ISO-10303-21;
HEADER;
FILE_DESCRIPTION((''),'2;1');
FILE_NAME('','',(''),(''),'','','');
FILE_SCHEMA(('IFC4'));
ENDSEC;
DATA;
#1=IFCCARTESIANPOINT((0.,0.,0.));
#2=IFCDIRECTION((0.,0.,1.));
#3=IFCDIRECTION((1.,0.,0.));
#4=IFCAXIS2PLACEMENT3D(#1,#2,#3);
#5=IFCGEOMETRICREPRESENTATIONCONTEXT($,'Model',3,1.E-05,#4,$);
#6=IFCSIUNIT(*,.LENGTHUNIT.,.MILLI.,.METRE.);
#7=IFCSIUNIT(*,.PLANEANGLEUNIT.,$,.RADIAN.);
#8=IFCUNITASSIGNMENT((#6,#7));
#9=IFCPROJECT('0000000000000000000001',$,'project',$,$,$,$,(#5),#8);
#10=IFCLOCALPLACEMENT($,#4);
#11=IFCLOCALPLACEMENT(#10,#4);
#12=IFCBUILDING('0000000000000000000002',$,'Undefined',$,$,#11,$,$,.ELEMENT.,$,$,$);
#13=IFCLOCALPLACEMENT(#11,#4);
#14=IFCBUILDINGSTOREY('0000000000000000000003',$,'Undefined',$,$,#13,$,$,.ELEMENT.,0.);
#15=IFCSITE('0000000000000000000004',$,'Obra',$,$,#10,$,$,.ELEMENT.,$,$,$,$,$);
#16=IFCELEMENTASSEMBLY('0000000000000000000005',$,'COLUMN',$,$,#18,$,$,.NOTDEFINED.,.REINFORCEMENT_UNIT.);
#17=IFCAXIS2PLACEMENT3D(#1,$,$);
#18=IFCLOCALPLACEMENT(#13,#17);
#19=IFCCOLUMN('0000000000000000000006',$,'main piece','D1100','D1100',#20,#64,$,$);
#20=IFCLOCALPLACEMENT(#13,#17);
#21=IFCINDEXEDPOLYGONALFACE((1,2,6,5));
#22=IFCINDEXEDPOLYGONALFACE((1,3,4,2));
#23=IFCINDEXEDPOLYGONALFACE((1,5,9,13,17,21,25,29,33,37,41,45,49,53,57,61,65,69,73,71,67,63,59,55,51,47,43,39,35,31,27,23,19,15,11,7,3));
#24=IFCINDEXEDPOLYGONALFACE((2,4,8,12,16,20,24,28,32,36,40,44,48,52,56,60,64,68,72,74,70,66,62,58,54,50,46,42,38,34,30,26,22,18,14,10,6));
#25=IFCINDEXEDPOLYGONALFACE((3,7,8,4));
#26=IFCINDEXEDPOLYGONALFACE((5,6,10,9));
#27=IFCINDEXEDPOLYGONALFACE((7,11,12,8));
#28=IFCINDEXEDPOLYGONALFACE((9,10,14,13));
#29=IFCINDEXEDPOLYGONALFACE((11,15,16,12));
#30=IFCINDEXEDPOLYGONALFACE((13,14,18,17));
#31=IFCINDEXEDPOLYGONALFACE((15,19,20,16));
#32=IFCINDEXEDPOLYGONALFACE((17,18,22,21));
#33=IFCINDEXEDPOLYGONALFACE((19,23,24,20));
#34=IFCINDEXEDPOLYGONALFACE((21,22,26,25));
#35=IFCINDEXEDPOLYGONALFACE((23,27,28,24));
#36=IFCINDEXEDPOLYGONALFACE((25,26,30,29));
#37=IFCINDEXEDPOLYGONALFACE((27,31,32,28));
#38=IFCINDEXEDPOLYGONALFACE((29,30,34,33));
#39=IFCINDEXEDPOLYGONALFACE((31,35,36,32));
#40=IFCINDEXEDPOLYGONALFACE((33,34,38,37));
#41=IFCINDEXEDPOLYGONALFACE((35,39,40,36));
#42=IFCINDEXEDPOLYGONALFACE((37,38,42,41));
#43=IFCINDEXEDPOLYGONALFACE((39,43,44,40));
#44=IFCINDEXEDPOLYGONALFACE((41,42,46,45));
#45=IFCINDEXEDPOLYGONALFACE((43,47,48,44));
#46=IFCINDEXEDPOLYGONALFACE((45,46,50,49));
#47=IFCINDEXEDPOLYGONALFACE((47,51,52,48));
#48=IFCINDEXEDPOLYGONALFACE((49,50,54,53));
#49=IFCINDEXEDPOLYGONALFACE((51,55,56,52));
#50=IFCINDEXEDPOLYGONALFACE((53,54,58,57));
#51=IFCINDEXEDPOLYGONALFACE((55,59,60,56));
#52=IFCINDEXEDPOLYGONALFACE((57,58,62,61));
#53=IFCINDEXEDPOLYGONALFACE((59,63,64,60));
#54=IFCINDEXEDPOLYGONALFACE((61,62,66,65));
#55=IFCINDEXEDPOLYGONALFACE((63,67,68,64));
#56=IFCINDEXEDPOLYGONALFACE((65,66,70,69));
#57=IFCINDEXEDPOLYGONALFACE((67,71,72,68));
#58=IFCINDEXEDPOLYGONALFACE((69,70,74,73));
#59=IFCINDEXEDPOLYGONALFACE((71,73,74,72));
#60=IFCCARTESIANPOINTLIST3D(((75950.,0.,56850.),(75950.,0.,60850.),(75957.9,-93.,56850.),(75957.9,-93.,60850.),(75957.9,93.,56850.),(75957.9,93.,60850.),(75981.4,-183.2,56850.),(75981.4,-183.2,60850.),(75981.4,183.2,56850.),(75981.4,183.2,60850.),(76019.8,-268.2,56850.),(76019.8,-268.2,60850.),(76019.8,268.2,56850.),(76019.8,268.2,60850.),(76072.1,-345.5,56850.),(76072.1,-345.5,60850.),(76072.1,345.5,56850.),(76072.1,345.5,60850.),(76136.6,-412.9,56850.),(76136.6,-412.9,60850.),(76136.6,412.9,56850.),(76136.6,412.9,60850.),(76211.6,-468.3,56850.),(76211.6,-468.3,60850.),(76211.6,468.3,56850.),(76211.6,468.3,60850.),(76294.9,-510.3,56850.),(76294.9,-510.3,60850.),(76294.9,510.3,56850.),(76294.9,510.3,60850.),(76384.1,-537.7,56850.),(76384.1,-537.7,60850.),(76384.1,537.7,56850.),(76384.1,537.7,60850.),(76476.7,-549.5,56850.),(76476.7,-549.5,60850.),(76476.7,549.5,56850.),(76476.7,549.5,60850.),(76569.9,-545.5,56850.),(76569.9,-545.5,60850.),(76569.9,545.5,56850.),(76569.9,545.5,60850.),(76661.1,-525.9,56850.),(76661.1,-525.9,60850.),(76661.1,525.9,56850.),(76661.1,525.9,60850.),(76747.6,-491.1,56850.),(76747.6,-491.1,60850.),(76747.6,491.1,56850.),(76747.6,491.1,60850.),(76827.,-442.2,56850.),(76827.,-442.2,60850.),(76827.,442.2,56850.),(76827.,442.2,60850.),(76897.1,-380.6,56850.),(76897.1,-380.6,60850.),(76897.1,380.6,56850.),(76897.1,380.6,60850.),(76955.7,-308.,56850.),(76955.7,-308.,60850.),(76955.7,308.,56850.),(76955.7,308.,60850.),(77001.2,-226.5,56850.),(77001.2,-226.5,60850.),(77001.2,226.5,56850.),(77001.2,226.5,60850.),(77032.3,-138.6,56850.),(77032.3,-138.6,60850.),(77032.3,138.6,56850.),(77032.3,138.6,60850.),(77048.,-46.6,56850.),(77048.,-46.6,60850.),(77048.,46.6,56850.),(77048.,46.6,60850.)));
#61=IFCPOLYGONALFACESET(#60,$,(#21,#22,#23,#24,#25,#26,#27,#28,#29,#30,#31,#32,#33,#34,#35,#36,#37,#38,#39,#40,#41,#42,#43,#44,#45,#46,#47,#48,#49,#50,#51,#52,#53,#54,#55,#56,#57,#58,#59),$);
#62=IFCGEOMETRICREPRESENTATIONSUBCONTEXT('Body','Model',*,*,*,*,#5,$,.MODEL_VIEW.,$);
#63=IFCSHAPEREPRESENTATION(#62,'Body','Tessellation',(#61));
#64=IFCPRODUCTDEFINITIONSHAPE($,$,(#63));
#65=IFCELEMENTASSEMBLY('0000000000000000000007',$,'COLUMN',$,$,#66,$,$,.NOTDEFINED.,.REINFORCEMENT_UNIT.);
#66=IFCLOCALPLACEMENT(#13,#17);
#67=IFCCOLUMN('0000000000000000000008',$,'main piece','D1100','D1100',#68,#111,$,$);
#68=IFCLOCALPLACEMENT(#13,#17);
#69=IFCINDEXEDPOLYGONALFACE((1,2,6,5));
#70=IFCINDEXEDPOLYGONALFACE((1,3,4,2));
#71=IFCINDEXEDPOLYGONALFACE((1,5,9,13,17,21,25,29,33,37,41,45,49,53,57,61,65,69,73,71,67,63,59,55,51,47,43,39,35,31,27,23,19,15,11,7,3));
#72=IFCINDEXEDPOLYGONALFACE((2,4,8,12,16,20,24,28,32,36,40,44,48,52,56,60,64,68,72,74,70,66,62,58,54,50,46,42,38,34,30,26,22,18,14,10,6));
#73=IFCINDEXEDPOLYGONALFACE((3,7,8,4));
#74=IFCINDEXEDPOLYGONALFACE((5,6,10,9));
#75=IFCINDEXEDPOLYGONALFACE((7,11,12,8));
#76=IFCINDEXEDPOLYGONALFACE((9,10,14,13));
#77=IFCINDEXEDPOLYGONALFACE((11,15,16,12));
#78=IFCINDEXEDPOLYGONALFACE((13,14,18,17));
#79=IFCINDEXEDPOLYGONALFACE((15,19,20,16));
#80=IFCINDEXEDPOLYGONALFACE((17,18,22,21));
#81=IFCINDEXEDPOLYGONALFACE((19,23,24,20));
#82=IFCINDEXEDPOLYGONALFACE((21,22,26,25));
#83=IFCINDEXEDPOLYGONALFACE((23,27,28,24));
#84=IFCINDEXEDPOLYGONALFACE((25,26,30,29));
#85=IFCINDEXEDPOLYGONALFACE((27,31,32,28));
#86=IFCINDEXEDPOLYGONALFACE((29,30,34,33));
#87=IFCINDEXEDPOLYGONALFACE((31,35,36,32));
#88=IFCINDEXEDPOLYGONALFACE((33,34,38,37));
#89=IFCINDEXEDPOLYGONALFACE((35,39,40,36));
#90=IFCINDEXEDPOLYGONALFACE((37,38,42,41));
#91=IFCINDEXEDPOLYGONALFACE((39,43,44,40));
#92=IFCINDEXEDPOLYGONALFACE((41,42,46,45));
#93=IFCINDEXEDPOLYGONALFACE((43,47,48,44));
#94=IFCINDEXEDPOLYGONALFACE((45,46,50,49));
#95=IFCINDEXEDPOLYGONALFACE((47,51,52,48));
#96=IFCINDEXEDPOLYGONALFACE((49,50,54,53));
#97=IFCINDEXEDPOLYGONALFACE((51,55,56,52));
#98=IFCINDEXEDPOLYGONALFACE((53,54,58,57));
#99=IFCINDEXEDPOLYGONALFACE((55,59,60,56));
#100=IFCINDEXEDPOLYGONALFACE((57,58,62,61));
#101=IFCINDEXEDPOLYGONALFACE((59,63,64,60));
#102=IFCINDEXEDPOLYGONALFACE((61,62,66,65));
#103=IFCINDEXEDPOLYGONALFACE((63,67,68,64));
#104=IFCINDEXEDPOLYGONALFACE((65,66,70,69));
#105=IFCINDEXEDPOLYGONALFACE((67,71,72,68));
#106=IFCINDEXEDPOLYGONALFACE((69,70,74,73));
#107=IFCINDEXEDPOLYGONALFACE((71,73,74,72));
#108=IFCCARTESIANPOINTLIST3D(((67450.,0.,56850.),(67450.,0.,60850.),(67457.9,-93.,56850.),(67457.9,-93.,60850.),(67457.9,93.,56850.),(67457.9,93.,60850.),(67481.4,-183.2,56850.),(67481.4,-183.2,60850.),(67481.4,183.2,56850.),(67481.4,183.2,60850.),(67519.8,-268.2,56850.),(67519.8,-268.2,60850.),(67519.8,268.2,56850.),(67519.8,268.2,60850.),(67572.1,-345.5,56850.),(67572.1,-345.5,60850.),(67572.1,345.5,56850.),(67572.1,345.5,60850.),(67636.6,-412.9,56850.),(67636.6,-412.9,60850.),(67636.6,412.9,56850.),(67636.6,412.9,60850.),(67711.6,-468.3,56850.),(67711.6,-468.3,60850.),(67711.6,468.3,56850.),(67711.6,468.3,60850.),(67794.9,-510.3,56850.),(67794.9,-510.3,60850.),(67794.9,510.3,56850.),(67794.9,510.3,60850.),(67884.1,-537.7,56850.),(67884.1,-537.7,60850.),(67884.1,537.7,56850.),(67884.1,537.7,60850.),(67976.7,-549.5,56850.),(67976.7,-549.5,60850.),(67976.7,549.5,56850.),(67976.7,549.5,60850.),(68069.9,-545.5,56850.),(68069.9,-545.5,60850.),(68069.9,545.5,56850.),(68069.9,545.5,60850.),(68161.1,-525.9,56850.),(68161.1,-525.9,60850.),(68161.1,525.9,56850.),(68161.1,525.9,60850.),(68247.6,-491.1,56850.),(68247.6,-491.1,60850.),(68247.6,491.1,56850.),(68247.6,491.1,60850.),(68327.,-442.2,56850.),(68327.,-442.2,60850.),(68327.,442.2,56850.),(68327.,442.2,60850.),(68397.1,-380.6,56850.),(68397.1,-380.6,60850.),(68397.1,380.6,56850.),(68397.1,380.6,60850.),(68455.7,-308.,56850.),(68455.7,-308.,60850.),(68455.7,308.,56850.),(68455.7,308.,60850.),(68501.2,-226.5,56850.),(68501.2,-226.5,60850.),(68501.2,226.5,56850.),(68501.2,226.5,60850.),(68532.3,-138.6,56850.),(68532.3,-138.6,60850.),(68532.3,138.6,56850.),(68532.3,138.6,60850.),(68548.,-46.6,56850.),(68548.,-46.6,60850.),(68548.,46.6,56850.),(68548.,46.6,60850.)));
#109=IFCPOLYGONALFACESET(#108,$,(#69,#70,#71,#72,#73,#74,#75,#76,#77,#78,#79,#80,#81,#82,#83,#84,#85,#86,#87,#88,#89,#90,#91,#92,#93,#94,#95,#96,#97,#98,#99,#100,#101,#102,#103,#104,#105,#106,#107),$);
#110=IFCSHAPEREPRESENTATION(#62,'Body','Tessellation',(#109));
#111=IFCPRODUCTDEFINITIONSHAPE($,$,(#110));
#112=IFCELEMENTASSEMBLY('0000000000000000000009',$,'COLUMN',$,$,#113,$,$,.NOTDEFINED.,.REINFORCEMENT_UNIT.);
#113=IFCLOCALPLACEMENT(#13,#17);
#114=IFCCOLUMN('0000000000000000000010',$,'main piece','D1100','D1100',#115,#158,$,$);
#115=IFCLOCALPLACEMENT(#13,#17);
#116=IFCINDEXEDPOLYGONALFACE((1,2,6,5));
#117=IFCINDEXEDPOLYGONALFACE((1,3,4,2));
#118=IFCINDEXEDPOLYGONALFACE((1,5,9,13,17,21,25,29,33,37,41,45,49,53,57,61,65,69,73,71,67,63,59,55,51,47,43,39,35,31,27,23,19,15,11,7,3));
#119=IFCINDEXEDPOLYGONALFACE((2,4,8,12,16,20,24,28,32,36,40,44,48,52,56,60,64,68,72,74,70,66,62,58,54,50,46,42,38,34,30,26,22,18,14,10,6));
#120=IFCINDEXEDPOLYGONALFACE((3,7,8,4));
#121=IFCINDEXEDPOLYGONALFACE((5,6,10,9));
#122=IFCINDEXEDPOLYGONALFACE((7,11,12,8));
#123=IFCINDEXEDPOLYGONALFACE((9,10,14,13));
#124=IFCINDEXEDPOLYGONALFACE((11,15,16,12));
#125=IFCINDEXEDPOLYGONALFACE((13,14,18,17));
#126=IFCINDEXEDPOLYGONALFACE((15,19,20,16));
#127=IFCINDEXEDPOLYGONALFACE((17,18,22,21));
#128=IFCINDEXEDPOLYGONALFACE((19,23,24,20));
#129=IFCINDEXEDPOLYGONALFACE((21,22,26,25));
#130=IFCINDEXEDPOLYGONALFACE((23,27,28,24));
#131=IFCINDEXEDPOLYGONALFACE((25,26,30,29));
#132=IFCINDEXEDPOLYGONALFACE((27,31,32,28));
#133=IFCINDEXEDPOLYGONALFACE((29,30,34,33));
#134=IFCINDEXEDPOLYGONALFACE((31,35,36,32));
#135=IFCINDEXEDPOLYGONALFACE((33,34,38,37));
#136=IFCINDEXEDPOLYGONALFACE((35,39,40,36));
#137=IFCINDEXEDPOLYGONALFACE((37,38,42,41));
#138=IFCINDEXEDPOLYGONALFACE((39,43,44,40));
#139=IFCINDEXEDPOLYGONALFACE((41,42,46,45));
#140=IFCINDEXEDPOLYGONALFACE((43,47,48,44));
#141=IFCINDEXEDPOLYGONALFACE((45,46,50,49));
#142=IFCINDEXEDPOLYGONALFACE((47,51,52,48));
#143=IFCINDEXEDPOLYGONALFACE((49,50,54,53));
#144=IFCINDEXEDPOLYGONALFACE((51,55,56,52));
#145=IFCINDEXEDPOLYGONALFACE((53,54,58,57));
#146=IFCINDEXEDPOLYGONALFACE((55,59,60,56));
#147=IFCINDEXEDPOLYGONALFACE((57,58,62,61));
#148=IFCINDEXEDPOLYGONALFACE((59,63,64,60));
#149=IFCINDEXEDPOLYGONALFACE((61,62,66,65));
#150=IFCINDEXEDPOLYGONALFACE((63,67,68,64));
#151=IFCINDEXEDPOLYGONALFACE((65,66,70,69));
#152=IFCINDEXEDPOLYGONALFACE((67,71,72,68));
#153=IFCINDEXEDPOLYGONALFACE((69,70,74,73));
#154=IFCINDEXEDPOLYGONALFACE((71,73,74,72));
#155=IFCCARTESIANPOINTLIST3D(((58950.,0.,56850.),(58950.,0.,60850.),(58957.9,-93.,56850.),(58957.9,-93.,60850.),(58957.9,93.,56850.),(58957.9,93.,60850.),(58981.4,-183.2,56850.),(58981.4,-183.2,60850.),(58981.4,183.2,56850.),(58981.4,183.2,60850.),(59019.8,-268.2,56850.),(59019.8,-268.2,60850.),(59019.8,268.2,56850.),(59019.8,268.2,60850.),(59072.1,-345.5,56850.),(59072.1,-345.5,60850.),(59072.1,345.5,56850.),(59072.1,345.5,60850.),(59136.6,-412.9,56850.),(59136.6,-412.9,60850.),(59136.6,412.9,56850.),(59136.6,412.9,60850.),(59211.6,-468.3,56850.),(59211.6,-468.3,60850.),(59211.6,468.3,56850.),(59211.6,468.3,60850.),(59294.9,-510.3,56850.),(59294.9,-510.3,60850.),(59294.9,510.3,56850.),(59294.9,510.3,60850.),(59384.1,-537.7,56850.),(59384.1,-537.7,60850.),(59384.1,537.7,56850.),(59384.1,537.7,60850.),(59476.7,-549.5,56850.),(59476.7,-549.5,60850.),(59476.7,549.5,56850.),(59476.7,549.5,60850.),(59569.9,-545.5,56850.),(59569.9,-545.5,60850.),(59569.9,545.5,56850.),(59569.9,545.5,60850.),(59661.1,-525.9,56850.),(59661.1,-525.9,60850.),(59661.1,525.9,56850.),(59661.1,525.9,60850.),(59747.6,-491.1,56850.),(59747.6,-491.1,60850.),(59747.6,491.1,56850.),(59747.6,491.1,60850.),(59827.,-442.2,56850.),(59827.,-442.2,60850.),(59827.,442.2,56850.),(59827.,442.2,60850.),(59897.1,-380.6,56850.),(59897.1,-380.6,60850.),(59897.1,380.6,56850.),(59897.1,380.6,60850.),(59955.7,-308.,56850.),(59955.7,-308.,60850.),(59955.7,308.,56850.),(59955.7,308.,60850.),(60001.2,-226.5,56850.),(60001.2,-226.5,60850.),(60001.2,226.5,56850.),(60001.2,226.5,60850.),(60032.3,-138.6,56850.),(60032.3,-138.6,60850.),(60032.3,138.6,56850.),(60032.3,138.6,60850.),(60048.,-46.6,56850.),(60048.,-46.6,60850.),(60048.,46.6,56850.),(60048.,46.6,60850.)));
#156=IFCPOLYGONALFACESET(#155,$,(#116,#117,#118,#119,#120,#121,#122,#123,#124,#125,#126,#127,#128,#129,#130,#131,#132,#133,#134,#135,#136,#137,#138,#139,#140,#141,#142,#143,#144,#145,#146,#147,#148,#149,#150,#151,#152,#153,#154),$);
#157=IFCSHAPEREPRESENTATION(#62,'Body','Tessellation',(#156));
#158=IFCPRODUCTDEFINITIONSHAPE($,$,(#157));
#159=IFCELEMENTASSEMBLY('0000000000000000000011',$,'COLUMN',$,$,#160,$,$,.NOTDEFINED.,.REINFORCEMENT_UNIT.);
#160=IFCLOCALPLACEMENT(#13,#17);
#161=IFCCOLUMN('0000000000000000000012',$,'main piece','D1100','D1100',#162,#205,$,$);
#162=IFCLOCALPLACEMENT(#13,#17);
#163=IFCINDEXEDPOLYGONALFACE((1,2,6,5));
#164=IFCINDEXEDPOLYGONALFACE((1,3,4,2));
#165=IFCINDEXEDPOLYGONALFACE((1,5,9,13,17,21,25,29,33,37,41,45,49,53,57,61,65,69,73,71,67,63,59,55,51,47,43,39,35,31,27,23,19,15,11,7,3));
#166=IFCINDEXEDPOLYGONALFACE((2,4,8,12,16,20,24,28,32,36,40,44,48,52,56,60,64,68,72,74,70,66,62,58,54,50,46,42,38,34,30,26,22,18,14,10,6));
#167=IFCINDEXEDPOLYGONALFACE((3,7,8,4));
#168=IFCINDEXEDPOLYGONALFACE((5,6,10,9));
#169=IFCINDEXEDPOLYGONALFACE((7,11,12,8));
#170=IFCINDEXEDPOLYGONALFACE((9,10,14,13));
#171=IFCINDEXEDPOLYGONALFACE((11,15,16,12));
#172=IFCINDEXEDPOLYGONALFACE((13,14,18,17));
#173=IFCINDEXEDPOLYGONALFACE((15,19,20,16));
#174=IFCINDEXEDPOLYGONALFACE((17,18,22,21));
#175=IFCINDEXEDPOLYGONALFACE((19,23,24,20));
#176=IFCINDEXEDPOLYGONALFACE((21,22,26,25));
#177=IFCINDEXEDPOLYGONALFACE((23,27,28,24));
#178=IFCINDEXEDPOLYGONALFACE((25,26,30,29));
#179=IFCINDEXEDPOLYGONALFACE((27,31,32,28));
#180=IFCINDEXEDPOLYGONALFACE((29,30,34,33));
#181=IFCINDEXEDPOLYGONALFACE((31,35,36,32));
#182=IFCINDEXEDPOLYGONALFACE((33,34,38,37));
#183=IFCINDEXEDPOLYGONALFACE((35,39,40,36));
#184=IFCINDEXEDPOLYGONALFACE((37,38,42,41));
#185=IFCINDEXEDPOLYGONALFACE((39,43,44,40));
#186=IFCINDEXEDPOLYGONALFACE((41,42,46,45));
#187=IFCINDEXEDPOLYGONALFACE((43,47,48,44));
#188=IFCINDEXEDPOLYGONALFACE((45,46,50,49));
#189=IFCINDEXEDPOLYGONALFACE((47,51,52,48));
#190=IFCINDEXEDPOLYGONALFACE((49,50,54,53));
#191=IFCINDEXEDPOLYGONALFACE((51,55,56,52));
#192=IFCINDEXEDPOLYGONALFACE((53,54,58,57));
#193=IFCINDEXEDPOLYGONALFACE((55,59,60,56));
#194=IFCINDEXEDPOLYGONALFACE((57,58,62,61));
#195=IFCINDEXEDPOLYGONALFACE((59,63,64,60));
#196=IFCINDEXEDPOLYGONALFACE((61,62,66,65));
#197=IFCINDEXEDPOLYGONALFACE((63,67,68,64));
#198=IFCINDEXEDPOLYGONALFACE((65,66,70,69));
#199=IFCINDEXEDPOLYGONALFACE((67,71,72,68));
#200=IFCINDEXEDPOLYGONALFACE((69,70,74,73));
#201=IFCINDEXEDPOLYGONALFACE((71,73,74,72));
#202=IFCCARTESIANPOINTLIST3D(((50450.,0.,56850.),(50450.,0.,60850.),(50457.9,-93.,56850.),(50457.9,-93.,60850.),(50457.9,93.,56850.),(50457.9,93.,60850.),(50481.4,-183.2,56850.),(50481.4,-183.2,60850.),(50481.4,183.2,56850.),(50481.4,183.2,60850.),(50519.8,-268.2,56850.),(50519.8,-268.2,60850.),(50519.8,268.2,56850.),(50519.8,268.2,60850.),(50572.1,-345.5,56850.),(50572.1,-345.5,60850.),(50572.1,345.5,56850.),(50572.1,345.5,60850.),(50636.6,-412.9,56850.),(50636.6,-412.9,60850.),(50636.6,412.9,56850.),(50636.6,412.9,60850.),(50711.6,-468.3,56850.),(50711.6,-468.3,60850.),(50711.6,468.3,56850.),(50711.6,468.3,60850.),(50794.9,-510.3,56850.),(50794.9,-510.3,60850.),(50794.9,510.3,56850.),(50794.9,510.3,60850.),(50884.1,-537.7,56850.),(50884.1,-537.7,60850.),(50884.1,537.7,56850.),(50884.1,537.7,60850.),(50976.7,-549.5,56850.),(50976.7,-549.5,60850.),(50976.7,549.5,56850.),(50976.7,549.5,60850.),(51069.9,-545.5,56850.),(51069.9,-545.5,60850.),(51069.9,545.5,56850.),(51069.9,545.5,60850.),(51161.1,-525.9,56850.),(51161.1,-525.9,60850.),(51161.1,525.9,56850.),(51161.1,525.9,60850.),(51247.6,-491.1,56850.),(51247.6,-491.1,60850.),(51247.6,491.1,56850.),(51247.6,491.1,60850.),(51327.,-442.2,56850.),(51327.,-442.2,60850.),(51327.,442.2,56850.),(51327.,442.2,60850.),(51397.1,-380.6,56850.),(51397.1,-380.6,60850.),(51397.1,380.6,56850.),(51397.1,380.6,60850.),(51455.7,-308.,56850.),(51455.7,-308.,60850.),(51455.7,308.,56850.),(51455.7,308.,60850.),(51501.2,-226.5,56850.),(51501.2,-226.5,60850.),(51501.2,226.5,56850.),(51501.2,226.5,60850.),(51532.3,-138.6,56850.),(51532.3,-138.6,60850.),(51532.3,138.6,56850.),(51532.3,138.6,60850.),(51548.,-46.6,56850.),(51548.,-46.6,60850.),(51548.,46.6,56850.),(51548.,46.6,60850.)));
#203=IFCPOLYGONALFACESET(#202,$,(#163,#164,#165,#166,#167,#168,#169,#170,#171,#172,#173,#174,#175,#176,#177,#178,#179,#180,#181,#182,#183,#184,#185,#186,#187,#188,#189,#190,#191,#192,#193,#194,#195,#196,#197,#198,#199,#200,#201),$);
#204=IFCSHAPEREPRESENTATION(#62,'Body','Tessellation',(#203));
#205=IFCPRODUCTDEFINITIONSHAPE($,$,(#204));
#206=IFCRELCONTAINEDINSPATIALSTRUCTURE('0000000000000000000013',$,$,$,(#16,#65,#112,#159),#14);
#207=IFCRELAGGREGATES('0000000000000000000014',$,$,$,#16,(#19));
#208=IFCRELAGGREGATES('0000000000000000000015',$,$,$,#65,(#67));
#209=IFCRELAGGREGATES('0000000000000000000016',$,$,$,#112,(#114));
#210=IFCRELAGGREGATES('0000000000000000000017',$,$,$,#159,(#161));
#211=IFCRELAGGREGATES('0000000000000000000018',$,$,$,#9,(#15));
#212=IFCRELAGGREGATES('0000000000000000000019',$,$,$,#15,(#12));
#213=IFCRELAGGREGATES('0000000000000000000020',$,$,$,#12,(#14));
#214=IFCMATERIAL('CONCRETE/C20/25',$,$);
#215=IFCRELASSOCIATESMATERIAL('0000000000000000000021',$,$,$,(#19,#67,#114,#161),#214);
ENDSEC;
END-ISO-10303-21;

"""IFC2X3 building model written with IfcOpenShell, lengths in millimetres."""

from ifc_helpers import new_model, si_unit, frame, origin_with_axes, origin_2d_with_axis, place, context, subcontext, project, spatial, circle, extrude, material, element, aggregate, save


model = new_model("IFC2X3")

# Units and contexts
model_context = context("Model", 3, precision=1e-05, world=origin_with_axes())
body_context = subcontext(model_context, "Body", "Model", "MODEL_VIEW")
ifc_project = project(units=[si_unit("LENGTHUNIT", "METRE", prefix="MILLI"), si_unit("PLANEANGLEUNIT", "RADIAN")], contexts=[model_context])

# Site, building, storey
site_placement = place(None, origin_with_axes())
site = spatial("IfcSite", under=ifc_project, at=site_placement, Name="Obra", CompositionType="ELEMENT")
building_placement = place(site_placement, origin_with_axes())
building = spatial("IfcBuilding", under=site, at=building_placement, Name="Undefined", CompositionType="ELEMENT")
storey_placement = place(building_placement, origin_with_axes())
storey = spatial("IfcBuildingStorey", under=building, at=storey_placement, Name="Undefined", CompositionType="ELEMENT", Elevation=0.0)

# Element assemblies, columns
ifc_material_1 = material(Name="CONCRETE/C20/25")
assembly_1_placement = place(storey_placement, origin_with_axes())
assembly_1 = element("IfcElementAssembly", 1, at=assembly_1_placement, inside=storey, Name="COLUMN", AssemblyPlace="NOTDEFINED", PredefinedType="REINFORCEMENT_UNIT")
column_1_placement = place(assembly_1_placement, frame((76500.0, 0.0, 56850.0), z_axis=(0.0, 0.0, 1.0), x_axis=(0.0, 1.0, 0.0)))
column_1 = element("IfcColumn", 2, at=column_1_placement, material=ifc_material_1, Name="main piece", Description="D1100", ObjectType="D1100", context=body_context, shape_type="SweptSolid", body=[
    extrude(circle(Radius=550.0, at=origin_2d_with_axis()), frame((0.0, 0.0, 4000.0), z_axis=(0.0, 0.0, -1.0), x_axis=(0.0, 1.0, 0.0)), (0.0, 0.0, 1.0), 4000.0),
])
aggregate(assembly_1, [column_1])
assembly_2_placement = place(storey_placement, origin_with_axes())
assembly_2 = element("IfcElementAssembly", 3, at=assembly_2_placement, inside=storey, Name="COLUMN", AssemblyPlace="NOTDEFINED", PredefinedType="REINFORCEMENT_UNIT")
column_2_placement = place(assembly_2_placement, frame((68000.0, 0.0, 56850.0), z_axis=(0.0, 0.0, 1.0), x_axis=(0.0, 1.0, 0.0)))
column_2 = element("IfcColumn", 4, at=column_2_placement, material=ifc_material_1, Name="main piece", Description="D1100", ObjectType="D1100", context=body_context, shape_type="SweptSolid", body=[
    extrude(circle(Radius=550.0, at=origin_2d_with_axis()), frame((0.0, 0.0, 4000.0), z_axis=(0.0, 0.0, -1.0), x_axis=(0.0, 1.0, 0.0)), (0.0, 0.0, 1.0), 4000.0),
])
aggregate(assembly_2, [column_2])
assembly_3_placement = place(storey_placement, origin_with_axes())
assembly_3 = element("IfcElementAssembly", 5, at=assembly_3_placement, inside=storey, Name="COLUMN", AssemblyPlace="NOTDEFINED", PredefinedType="REINFORCEMENT_UNIT")
column_3_placement = place(assembly_3_placement, frame((59500.0, 0.0, 56850.0), z_axis=(0.0, 0.0, 1.0), x_axis=(0.0, 1.0, 0.0)))
column_3 = element("IfcColumn", 6, at=column_3_placement, material=ifc_material_1, Name="main piece", Description="D1100", ObjectType="D1100", context=body_context, shape_type="SweptSolid", body=[
    extrude(circle(Radius=550.0, at=origin_2d_with_axis()), frame((0.0, 0.0, 4000.0), z_axis=(0.0, 0.0, -1.0), x_axis=(0.0, 1.0, 0.0)), (0.0, 0.0, 1.0), 4000.0),
])
aggregate(assembly_3, [column_3])
assembly_4_placement = place(storey_placement, origin_with_axes())
assembly_4 = element("IfcElementAssembly", 7, at=assembly_4_placement, inside=storey, Name="COLUMN", AssemblyPlace="NOTDEFINED", PredefinedType="REINFORCEMENT_UNIT")
column_4_placement = place(assembly_4_placement, frame((51000.0, 0.0, 56850.0), z_axis=(0.0, 0.0, 1.0), x_axis=(0.0, 1.0, 0.0)))
column_4 = element("IfcColumn", 8, at=column_4_placement, material=ifc_material_1, Name="main piece", Description="D1100", ObjectType="D1100", context=body_context, shape_type="SweptSolid", body=[
    extrude(circle(Radius=550.0, at=origin_2d_with_axis()), frame((0.0, 0.0, 4000.0), z_axis=(0.0, 0.0, -1.0), x_axis=(0.0, 1.0, 0.0)), (0.0, 0.0, 1.0), 4000.0),
])
aggregate(assembly_4, [column_4])

save(model, "model.ifc")
